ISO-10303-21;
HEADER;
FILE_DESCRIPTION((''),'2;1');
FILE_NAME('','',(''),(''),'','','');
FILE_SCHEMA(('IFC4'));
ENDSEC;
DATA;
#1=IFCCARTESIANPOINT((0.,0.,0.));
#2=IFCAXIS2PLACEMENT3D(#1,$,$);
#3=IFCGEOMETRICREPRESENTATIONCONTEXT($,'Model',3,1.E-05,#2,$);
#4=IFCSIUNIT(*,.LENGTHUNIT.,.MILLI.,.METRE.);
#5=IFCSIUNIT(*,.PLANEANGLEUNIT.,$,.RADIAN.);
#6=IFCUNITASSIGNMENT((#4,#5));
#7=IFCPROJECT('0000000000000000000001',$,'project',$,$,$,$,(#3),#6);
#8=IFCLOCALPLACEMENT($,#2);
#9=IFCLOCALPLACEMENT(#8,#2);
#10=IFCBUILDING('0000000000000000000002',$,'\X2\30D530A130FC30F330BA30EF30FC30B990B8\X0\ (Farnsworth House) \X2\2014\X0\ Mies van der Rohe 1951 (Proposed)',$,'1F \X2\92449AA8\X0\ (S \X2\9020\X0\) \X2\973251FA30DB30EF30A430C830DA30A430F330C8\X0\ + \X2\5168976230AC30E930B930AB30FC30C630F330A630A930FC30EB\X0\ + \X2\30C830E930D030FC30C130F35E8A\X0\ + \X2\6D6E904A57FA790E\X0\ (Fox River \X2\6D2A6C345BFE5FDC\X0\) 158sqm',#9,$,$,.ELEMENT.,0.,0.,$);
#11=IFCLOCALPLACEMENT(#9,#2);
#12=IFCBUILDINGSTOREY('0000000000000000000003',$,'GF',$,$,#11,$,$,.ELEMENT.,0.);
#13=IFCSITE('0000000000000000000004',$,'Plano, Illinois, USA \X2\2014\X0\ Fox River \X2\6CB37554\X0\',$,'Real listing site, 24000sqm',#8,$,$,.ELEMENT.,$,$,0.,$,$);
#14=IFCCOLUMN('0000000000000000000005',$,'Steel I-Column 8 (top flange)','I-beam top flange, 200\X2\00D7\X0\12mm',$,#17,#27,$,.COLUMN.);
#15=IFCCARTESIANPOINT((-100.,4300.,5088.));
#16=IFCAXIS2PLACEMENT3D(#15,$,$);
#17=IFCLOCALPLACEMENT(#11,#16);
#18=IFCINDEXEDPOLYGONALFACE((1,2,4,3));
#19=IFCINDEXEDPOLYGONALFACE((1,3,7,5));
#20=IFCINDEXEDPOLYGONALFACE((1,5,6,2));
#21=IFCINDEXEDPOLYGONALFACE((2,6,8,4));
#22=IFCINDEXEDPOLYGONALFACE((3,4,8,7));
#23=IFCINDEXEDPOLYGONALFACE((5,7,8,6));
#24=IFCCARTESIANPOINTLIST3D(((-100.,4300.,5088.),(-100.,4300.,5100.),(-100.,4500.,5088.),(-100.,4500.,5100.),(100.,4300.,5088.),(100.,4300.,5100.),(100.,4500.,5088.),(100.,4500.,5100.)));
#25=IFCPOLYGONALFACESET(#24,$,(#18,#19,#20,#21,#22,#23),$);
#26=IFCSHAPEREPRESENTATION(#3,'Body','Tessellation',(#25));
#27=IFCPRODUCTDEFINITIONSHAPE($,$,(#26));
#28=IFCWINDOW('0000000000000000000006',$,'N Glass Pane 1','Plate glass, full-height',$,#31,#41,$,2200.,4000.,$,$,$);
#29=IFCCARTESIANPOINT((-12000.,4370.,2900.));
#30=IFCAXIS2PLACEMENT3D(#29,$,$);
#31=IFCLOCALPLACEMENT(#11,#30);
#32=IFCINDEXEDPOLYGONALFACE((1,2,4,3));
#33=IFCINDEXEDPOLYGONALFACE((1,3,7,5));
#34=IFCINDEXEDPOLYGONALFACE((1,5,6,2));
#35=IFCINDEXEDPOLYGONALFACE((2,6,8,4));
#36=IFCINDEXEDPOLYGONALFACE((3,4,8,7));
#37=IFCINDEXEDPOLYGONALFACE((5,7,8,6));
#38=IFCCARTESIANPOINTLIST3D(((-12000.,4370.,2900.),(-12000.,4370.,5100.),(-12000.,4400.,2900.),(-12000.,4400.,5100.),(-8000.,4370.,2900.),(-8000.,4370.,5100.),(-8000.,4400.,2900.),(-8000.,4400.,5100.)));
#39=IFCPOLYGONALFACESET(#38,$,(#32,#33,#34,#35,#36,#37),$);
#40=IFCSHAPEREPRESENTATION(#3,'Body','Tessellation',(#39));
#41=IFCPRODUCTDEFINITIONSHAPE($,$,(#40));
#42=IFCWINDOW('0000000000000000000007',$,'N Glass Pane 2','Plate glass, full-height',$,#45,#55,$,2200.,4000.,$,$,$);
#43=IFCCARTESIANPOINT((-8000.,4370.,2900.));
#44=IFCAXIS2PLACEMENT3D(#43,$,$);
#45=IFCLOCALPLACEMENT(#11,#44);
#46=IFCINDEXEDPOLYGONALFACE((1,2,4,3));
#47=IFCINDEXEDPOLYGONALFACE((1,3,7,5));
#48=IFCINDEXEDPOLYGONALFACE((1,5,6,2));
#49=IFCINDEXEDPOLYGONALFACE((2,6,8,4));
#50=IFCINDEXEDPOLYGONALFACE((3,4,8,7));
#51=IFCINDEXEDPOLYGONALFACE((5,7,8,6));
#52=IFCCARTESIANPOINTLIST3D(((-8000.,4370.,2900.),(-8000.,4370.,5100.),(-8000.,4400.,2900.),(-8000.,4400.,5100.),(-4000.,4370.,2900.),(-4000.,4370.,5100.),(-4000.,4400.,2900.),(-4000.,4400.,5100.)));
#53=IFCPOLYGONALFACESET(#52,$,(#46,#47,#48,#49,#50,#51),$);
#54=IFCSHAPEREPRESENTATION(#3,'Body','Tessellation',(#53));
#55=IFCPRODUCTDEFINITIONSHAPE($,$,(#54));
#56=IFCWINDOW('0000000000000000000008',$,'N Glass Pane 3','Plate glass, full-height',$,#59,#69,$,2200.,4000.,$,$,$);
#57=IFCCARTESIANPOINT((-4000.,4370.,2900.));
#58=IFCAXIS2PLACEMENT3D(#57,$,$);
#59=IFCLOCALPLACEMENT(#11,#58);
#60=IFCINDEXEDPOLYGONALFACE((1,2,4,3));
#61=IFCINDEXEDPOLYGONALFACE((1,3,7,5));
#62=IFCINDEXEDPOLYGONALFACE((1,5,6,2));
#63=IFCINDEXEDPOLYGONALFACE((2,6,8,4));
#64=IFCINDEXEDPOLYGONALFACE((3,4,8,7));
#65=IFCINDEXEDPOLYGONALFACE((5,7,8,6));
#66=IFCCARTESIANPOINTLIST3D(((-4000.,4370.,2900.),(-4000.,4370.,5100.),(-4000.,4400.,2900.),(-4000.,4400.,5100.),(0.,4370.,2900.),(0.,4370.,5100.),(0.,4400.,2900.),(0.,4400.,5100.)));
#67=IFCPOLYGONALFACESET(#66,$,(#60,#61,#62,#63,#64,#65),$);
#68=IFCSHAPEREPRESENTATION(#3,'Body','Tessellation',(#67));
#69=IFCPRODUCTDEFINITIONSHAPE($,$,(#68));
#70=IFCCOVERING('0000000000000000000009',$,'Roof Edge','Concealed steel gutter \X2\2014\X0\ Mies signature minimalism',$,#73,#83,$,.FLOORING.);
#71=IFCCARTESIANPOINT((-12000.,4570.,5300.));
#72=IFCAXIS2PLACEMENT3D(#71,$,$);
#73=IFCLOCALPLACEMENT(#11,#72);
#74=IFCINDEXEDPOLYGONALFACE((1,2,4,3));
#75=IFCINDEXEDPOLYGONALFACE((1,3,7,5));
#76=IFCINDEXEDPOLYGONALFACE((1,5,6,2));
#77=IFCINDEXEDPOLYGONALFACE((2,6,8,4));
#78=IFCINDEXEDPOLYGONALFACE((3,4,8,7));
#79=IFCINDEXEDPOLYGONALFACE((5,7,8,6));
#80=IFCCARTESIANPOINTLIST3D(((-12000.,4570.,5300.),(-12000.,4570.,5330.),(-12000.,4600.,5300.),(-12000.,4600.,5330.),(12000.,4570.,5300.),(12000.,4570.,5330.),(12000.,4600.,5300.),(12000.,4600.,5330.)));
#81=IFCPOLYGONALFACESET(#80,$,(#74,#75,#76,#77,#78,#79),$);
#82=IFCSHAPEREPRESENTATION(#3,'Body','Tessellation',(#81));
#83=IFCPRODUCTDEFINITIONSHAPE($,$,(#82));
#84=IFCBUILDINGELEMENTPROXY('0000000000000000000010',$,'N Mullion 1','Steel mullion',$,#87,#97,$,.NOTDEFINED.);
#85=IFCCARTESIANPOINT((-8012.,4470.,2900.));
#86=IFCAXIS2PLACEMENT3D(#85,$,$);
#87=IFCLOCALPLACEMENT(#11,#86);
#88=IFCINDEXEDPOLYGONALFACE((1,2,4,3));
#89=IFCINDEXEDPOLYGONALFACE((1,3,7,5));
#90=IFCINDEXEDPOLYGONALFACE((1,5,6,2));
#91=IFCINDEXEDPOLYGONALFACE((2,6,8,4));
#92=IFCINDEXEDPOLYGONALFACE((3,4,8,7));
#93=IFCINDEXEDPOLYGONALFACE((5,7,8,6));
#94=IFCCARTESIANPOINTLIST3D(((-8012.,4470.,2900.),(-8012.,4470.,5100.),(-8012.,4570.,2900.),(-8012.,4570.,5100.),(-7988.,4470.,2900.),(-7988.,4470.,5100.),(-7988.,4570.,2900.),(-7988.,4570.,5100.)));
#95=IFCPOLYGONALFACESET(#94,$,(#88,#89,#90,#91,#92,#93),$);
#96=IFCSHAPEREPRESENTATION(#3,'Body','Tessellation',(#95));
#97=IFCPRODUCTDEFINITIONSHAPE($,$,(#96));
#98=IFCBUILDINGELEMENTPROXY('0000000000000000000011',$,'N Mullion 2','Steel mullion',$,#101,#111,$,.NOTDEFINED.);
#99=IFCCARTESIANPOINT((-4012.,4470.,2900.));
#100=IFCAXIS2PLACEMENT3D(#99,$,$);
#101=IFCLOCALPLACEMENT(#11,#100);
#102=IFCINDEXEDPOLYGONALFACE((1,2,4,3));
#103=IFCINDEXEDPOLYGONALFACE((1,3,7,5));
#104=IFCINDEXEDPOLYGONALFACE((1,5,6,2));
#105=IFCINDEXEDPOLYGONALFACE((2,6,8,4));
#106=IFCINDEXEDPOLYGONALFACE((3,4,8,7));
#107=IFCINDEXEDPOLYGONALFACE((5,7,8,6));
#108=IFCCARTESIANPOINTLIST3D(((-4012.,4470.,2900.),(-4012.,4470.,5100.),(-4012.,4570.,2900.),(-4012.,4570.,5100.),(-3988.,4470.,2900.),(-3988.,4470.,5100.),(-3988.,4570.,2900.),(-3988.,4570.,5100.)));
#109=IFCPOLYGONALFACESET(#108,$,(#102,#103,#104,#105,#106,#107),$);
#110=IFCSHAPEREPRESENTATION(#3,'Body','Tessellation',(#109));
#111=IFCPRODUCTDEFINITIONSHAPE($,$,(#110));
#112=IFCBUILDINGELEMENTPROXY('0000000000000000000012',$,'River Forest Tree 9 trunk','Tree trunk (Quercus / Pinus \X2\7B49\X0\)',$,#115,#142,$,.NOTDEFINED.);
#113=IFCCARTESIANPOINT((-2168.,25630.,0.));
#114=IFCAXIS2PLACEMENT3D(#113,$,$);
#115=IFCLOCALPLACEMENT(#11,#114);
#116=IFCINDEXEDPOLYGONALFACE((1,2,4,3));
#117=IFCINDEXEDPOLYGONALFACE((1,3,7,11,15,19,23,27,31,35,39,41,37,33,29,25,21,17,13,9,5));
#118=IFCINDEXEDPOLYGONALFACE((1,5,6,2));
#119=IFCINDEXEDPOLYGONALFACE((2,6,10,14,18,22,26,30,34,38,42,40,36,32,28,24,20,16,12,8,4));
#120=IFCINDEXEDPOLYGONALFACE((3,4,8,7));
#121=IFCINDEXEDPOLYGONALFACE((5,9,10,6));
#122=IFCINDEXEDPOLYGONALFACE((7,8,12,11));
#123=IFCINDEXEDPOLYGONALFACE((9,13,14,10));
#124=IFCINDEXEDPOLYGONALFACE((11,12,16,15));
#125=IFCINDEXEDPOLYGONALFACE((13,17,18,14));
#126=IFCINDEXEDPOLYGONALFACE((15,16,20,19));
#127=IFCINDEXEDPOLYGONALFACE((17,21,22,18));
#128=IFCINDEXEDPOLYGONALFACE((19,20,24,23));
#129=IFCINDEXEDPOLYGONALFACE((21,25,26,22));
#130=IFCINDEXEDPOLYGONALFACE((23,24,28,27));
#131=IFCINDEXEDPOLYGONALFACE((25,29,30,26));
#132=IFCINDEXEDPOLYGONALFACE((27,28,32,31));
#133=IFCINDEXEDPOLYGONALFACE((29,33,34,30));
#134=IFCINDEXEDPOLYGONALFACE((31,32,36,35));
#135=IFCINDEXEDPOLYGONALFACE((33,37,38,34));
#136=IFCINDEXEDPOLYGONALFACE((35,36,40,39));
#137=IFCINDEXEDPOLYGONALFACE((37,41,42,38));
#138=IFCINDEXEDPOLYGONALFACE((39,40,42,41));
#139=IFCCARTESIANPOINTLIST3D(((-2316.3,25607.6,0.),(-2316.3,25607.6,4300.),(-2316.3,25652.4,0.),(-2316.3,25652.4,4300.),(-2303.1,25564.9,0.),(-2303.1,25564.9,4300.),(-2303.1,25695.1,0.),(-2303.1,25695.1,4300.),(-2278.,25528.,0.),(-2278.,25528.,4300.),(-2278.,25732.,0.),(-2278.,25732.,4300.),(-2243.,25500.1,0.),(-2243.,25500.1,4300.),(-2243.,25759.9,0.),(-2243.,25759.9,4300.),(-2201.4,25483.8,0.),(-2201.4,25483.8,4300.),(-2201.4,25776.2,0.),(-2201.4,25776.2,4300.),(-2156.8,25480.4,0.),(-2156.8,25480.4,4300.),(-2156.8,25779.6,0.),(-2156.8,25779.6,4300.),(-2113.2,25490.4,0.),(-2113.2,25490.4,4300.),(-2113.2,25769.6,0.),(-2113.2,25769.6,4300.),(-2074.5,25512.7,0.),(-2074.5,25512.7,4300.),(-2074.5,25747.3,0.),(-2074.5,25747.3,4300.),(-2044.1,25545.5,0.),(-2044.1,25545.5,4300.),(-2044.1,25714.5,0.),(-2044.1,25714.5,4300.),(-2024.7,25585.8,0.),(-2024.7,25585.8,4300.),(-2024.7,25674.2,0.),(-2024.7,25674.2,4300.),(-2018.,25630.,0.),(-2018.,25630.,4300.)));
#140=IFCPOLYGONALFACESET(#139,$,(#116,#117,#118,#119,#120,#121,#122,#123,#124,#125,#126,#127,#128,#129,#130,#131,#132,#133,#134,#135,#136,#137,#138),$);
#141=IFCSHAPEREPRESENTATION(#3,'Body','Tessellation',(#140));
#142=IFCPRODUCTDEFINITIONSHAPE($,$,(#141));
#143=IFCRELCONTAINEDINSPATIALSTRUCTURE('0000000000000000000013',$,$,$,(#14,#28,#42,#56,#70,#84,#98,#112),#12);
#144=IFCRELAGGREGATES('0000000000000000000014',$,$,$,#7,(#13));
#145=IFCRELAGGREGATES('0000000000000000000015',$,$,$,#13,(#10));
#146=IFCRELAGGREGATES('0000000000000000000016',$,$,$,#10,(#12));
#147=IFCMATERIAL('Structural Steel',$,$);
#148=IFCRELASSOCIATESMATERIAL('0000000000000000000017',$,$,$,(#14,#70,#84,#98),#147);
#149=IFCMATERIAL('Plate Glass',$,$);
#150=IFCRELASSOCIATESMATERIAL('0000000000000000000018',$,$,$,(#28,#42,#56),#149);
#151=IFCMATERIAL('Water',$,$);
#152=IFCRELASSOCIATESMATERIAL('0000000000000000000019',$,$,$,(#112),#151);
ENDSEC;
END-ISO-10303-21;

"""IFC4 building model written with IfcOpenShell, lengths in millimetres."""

from ifc_helpers import new_model, si_unit, frame, frame_2d, origin, origin_2d, place, context, project, spatial, rectangle, circle, extrude, material, element, save


model = new_model("IFC4")

# Units and contexts
model_context = context("Model", 3, precision=1e-05, world=origin())
ifc_project = project(units=[si_unit("LENGTHUNIT", "METRE", prefix="MILLI"), si_unit("PLANEANGLEUNIT", "RADIAN")], contexts=[model_context])

# Site, building, storey
site_placement = place(None, origin())
site = spatial("IfcSite", under=ifc_project, at=site_placement, Name="Plano, Illinois, USA — Fox River 河畔", ObjectType="Real listing site, 24000sqm", CompositionType="ELEMENT", RefElevation=0.0)
building_placement = place(site_placement, origin())
building = spatial("IfcBuilding", under=site, at=building_placement, Name="ファーンズワース邸 (Farnsworth House) — Mies van der Rohe 1951 (Proposed)", ObjectType="1F 鉄骨 (S 造) 露出ホワイトペイント + 全面ガラスカーテンウォール + トラバーチン床 + 浮遊基礎 (Fox River 洪水対応) 158sqm", CompositionType="ELEMENT", ElevationOfRefHeight=0.0, ElevationOfTerrain=0.0)
storey_placement = place(building_placement, origin())
storey = spatial("IfcBuildingStorey", under=building, at=storey_placement, Name="GF", CompositionType="ELEMENT", Elevation=0.0)

# Column
ifc_material_1 = material(Name="Structural Steel")
column_placement = place(storey_placement, frame((-100.0, 4300.0, 5088.0)))
element("IfcColumn", 1, at=column_placement, inside=storey, material=ifc_material_1, Name="Steel I-Column 8 (top flange)", Description="I-beam top flange, 200×12mm", PredefinedType="COLUMN", context=model_context, shape_type="SweptSolid", body=[
    extrude(rectangle(XDim=200.0, YDim=200.0, at=frame_2d((100.0, 100.0))), frame((-100.0, 4300.0, 5088.0)), (0.0, 0.0, 1.0), 12.0),
])

# Windows
ifc_material_2 = material(Name="Plate Glass")
window_1_placement = place(storey_placement, frame((-12000.0, 4370.0, 2900.0)))
element("IfcWindow", 2, at=window_1_placement, inside=storey, material=ifc_material_2, Name="N Glass Pane 1", Description="Plate glass, full-height", OverallHeight=2200.0, OverallWidth=4000.0, context=model_context, shape_type="SweptSolid", body=[
    extrude(rectangle(XDim=4000.0, YDim=30.0, at=frame_2d((2000.0, 15.0))), frame((-12000.0, 4370.0, 2900.0)), (0.0, 0.0, 1.0), 2200.0),
])
window_2_placement = place(storey_placement, frame((-8000.0, 4370.0, 2900.0)))
element("IfcWindow", 3, at=window_2_placement, inside=storey, material=ifc_material_2, Name="N Glass Pane 2", Description="Plate glass, full-height", OverallHeight=2200.0, OverallWidth=4000.0, context=model_context, shape_type="SweptSolid", body=[
    extrude(rectangle(XDim=4000.0, YDim=30.0, at=frame_2d((2000.0, 15.0))), frame((-8000.0, 4370.0, 2900.0)), (0.0, 0.0, 1.0), 2200.0),
])
window_3_placement = place(storey_placement, frame((-4000.0, 4370.0, 2900.0)))
element("IfcWindow", 4, at=window_3_placement, inside=storey, material=ifc_material_2, Name="N Glass Pane 3", Description="Plate glass, full-height", OverallHeight=2200.0, OverallWidth=4000.0, context=model_context, shape_type="SweptSolid", body=[
    extrude(rectangle(XDim=4000.0, YDim=30.0, at=frame_2d((2000.0, 15.0))), frame((-4000.0, 4370.0, 2900.0)), (0.0, 0.0, 1.0), 2200.0),
])

# Covering
covering_placement = place(storey_placement, frame((-12000.0, 4570.0, 5300.0)))
element("IfcCovering", 5, at=covering_placement, inside=storey, material=ifc_material_1, Name="Roof Edge", Description="Concealed steel gutter — Mies signature minimalism", PredefinedType="FLOORING", context=model_context, shape_type="SweptSolid", body=[
    extrude(rectangle(XDim=24000.0, YDim=30.0, at=frame_2d((12000.0, 15.0))), frame((-12000.0, 4570.0, 5300.0)), (0.0, 0.0, 1.0), 30.0),
])

# Building element proxies
proxy_1_placement = place(storey_placement, frame((-8012.0, 4470.0, 2900.0)))
element("IfcBuildingElementProxy", 6, at=proxy_1_placement, inside=storey, material=ifc_material_1, Name="N Mullion 1", Description="Steel mullion", PredefinedType="NOTDEFINED", context=model_context, shape_type="SweptSolid", body=[
    extrude(rectangle(XDim=24.0, YDim=100.0, at=frame_2d((12.0, 50.0))), frame((-8012.0, 4470.0, 2900.0)), (0.0, 0.0, 1.0), 2200.0),
])
proxy_2_placement = place(storey_placement, frame((-4012.0, 4470.0, 2900.0)))
element("IfcBuildingElementProxy", 7, at=proxy_2_placement, inside=storey, material=ifc_material_1, Name="N Mullion 2", Description="Steel mullion", PredefinedType="NOTDEFINED", context=model_context, shape_type="SweptSolid", body=[
    extrude(rectangle(XDim=24.0, YDim=100.0, at=frame_2d((12.0, 50.0))), frame((-4012.0, 4470.0, 2900.0)), (0.0, 0.0, 1.0), 2200.0),
])
ifc_material_3 = material(Name="Water")
proxy_3_placement = place(storey_placement, frame((-2168.0, 25630.0, 0.0)))
element("IfcBuildingElementProxy", 8, at=proxy_3_placement, inside=storey, material=ifc_material_3, Name="River Forest Tree 9 trunk", Description="Tree trunk (Quercus / Pinus 等)", PredefinedType="NOTDEFINED", context=model_context, shape_type="SweptSolid", body=[
    extrude(circle(Radius=150.0, at=origin_2d()), frame((-2168.0, 25630.0, 0.0)), (0.0, 0.0, 1.0), 4300.0),
])

save(model, "model.ifc")
